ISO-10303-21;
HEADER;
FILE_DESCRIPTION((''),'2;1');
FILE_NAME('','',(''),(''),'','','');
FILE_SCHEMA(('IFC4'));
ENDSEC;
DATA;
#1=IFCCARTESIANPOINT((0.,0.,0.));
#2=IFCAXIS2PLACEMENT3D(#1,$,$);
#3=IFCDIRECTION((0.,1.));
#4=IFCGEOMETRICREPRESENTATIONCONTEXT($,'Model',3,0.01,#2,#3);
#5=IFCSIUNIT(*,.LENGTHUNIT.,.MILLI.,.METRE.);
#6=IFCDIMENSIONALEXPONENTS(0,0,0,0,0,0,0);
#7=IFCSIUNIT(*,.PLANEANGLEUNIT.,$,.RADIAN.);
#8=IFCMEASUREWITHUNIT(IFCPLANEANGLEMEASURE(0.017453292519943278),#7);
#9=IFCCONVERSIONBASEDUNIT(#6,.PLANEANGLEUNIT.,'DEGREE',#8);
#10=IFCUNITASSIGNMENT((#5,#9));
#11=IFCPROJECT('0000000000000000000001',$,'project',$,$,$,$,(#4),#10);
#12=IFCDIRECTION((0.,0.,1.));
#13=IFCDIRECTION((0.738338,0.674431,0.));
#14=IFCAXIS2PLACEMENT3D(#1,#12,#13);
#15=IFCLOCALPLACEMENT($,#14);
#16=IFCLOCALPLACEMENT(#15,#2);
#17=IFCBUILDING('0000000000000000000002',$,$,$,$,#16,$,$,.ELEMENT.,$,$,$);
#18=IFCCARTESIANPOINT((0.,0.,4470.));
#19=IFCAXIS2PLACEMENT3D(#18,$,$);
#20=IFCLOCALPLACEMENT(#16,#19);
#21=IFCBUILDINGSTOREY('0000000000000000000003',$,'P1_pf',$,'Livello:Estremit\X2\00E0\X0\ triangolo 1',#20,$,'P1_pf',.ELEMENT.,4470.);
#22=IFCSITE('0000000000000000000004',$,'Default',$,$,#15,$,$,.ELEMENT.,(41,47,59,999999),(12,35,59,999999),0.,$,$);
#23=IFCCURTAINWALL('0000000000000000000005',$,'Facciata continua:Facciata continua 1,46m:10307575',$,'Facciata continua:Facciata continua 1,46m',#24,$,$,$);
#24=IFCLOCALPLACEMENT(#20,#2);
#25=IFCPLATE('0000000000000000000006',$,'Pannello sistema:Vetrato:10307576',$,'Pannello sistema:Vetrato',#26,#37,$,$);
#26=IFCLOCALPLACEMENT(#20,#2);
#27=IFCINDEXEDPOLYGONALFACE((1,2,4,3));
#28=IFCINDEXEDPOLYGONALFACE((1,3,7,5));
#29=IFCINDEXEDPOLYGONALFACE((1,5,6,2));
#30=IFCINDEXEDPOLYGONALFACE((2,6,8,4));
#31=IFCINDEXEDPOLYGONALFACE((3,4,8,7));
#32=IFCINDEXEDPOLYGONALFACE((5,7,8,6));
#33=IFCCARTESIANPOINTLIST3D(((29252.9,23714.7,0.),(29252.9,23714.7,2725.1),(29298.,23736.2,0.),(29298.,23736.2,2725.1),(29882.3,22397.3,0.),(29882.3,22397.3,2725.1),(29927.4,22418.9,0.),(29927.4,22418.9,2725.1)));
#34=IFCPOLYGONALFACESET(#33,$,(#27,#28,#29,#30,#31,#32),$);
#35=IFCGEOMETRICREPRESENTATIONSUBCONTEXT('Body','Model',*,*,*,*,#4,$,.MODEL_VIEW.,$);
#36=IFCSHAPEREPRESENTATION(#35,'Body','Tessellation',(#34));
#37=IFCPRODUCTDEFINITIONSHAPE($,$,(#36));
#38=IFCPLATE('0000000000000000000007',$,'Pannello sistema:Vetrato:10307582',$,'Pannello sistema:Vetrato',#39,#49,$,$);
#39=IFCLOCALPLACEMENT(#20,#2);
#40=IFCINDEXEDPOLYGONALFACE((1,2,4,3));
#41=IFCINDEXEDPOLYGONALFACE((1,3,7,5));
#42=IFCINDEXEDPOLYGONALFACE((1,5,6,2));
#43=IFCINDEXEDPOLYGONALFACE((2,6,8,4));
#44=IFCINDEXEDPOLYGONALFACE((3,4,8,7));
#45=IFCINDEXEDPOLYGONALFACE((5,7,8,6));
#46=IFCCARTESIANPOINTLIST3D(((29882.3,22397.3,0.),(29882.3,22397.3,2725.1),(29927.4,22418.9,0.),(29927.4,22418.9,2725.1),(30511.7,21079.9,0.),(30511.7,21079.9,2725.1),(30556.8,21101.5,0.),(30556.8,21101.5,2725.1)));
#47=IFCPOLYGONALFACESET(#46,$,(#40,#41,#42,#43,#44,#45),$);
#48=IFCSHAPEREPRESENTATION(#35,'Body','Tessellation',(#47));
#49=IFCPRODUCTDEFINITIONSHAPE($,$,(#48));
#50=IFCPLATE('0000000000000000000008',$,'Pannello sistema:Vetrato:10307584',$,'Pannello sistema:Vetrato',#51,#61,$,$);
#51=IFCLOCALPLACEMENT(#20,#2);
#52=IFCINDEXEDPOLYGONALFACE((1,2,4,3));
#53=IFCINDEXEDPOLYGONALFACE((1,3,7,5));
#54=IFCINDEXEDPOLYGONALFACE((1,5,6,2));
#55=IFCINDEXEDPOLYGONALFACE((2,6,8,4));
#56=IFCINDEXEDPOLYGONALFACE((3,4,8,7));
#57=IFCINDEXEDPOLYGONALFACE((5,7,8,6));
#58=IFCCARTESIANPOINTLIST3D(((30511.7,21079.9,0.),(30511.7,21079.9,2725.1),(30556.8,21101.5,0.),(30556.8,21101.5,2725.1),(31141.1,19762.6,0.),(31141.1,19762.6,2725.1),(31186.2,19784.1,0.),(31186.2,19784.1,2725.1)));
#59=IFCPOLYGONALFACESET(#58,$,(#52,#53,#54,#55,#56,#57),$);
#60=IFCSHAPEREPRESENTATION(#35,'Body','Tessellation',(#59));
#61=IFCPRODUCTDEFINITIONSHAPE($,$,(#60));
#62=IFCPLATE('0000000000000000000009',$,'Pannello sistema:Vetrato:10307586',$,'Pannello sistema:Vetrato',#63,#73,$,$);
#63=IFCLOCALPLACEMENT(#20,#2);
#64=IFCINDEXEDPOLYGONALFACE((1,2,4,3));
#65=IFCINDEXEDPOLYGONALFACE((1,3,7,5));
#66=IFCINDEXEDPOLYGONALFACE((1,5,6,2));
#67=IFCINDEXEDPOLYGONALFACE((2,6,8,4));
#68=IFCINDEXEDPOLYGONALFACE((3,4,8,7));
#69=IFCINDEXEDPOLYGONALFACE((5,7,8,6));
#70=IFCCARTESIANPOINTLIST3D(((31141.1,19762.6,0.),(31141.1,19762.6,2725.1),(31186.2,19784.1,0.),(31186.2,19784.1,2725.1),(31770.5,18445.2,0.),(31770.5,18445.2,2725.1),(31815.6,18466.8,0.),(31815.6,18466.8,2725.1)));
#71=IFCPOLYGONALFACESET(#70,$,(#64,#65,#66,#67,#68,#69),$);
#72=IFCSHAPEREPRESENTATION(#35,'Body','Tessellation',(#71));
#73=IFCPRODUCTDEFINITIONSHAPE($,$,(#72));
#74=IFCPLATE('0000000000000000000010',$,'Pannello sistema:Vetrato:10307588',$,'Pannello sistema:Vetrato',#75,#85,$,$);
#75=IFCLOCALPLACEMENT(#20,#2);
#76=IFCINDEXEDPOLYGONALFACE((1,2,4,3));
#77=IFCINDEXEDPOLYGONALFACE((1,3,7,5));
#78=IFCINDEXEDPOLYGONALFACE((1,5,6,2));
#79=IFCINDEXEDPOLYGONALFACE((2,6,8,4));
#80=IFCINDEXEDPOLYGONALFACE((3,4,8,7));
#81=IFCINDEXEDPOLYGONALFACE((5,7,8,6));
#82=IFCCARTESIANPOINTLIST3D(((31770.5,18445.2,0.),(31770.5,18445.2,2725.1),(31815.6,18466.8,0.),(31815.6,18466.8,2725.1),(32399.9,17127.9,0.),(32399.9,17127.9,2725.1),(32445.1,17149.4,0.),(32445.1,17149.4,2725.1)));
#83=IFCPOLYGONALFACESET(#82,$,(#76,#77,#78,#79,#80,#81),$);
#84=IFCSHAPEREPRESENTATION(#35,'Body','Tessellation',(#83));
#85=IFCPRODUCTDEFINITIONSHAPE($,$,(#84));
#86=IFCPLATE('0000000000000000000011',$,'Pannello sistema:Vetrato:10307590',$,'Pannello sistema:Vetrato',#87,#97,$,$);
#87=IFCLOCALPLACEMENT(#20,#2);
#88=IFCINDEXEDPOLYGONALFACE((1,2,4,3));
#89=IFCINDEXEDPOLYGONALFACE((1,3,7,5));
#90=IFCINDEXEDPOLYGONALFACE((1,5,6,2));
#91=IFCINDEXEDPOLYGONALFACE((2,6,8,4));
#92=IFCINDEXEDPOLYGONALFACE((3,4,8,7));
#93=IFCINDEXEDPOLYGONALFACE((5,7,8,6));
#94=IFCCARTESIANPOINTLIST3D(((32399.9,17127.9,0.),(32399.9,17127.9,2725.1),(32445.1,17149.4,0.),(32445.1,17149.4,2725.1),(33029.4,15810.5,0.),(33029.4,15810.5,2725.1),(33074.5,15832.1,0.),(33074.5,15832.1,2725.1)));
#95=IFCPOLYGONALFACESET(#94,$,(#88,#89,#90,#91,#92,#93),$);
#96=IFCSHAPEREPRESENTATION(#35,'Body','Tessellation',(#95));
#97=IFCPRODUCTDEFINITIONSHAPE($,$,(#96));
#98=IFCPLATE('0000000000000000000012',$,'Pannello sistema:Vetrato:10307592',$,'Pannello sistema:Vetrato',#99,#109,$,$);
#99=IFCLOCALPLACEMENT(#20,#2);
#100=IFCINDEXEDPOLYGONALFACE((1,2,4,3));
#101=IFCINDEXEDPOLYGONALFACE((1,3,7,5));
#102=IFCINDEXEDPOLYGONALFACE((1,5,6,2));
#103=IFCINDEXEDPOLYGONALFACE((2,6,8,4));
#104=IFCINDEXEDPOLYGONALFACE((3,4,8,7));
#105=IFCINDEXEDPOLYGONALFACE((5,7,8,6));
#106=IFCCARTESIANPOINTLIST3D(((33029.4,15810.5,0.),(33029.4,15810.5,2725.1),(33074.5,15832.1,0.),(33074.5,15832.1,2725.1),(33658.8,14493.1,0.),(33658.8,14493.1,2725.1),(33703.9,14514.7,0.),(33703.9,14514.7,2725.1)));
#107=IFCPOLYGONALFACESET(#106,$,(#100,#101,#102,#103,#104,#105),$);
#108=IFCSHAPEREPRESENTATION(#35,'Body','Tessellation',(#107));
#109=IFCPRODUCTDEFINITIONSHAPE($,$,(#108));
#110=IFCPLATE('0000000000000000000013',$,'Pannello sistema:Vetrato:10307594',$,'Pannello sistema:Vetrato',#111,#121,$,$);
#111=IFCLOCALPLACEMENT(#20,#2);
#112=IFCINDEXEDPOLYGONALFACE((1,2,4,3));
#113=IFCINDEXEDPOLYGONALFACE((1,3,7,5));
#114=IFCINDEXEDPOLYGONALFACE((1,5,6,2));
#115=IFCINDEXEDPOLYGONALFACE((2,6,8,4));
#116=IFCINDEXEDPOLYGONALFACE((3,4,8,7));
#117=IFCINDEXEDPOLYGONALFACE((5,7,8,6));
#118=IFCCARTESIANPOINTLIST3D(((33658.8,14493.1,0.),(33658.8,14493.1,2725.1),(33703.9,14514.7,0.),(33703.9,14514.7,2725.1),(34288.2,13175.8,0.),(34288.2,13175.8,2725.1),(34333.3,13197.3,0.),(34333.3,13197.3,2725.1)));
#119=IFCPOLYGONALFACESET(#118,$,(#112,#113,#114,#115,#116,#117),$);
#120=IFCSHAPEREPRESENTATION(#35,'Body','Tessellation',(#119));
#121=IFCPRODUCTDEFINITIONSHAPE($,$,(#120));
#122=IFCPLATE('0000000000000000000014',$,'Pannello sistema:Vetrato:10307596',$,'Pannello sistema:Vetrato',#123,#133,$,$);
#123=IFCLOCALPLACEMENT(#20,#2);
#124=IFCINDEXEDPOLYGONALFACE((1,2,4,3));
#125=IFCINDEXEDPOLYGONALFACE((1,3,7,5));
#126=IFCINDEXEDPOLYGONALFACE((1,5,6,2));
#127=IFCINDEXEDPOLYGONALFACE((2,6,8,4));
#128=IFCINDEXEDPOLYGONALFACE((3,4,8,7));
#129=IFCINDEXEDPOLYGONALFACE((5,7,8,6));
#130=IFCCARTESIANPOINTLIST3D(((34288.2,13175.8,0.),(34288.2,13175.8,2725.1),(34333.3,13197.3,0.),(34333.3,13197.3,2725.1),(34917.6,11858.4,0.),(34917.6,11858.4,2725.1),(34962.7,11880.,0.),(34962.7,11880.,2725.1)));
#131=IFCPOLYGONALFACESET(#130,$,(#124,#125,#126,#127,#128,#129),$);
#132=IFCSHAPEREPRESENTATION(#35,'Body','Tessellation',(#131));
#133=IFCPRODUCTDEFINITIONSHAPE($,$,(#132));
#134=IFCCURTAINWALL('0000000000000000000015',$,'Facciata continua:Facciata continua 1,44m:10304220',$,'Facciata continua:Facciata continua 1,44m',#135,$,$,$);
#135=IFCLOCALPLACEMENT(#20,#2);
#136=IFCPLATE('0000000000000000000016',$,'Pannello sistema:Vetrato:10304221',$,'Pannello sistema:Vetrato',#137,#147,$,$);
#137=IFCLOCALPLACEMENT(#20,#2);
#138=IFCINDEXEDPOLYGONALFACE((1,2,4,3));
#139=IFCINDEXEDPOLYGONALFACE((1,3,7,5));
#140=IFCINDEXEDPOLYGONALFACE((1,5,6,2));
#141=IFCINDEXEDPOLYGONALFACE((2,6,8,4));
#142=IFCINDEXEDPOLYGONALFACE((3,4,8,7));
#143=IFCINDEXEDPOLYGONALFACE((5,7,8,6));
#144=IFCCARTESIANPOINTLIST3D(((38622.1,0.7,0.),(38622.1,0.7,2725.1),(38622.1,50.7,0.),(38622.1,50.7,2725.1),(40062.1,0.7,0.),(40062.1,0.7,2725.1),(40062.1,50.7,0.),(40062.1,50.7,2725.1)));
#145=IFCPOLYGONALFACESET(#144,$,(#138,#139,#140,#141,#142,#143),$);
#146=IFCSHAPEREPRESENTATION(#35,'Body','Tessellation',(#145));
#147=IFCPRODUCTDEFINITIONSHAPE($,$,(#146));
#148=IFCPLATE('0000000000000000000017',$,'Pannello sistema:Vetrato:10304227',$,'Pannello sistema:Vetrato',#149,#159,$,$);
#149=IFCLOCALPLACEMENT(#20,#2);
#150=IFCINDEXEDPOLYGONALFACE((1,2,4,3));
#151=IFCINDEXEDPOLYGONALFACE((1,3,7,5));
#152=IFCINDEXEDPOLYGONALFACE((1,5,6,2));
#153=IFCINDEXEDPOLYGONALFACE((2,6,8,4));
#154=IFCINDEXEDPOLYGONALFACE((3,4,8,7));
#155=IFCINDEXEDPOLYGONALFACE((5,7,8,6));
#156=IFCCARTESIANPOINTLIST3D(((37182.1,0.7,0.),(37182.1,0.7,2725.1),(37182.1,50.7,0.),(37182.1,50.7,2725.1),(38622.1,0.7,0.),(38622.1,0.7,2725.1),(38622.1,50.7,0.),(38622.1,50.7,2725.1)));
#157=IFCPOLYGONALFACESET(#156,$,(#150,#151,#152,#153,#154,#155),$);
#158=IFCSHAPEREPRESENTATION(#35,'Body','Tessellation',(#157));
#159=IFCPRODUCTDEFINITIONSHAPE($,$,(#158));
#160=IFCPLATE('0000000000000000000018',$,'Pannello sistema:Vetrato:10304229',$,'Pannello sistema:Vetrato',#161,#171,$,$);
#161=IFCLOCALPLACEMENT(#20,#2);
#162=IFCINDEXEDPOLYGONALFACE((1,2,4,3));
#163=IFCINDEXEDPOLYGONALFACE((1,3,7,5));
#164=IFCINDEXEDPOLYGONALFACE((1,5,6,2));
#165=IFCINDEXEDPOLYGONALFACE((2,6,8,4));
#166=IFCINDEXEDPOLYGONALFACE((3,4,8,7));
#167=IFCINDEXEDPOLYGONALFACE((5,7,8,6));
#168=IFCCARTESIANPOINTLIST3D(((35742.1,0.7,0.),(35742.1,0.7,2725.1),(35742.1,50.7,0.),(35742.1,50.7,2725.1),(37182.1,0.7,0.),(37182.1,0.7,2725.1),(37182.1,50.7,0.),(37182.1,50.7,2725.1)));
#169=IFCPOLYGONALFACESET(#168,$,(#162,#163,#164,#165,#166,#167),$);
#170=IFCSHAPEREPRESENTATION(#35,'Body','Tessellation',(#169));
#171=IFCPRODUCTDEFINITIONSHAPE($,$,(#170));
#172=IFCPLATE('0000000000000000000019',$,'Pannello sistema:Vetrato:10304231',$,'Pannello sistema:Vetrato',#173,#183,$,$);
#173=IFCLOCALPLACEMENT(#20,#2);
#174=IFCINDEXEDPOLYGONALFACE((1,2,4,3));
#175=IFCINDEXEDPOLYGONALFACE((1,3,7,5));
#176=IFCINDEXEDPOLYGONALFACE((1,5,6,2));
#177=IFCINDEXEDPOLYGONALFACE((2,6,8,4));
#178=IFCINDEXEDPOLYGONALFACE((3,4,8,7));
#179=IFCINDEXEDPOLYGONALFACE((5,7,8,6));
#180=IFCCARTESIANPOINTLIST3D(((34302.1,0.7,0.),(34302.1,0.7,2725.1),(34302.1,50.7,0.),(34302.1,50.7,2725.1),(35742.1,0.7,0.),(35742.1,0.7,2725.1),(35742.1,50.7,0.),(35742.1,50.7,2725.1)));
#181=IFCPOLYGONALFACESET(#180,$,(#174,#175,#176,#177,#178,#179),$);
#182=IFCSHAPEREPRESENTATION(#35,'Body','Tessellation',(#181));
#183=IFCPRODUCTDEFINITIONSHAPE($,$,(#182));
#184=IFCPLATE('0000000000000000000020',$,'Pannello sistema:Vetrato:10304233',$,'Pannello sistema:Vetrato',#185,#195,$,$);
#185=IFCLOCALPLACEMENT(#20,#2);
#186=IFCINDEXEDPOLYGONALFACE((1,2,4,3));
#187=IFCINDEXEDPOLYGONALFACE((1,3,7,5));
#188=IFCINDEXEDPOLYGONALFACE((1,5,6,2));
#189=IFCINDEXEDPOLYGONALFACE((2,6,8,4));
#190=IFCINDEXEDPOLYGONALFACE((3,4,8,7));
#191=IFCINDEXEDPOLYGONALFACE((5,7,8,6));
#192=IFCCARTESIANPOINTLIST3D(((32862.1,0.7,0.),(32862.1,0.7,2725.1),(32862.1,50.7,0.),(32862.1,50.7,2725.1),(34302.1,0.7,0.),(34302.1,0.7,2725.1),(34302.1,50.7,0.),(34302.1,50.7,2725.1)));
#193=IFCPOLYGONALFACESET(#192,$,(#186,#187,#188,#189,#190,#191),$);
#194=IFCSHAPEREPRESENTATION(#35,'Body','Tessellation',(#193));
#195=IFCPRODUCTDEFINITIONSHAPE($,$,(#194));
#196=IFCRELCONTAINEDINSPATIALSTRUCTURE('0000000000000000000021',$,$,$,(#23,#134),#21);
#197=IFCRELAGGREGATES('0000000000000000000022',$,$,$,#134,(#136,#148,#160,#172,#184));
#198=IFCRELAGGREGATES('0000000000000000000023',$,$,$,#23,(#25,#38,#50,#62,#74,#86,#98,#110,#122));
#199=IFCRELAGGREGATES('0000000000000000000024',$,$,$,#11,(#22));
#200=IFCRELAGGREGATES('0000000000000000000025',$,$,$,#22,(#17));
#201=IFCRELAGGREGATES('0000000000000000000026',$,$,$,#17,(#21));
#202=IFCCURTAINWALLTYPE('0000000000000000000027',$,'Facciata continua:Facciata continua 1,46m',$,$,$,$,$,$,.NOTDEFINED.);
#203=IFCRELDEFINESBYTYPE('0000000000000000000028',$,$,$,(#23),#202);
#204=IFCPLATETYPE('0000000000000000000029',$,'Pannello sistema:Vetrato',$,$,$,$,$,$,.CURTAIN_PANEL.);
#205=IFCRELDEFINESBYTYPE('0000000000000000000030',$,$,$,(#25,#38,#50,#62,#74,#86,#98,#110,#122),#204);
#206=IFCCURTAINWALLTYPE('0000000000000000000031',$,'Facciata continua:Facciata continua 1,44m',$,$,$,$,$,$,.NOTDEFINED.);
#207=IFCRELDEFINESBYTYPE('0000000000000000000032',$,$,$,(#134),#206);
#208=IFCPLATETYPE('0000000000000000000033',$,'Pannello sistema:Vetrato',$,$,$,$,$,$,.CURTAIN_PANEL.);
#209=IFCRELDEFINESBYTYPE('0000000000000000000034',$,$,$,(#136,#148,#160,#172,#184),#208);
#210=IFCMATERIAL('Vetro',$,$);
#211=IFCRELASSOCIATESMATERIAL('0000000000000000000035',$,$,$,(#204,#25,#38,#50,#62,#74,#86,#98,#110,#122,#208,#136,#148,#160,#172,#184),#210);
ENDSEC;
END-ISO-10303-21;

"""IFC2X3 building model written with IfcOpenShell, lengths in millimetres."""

from ifc_helpers import new_model, entity, si_unit, converted_unit, direction, frame, origin, origin_2d_with_axis, place, context, subcontext, project, spatial, rectangle, extrude, source, transform, mapped, material, type_object, type_shapes, element, aggregate, save


model = new_model("IFC2X3")

# Units and contexts
model_context = context("Model", 3, precision=0.01, world=origin(), true_north=direction((0.0, 1.0)))
body_context = subcontext(model_context, "Body", "Model", "MODEL_VIEW")
ifc_project = project(units=[si_unit("LENGTHUNIT", "METRE", prefix="MILLI"), converted_unit("PLANEANGLEUNIT", "DEGREE", entity("IfcPlaneAngleMeasure", 0.017453292519943278), si_unit("PLANEANGLEUNIT", "RADIAN"), dimensions=[0, 0, 0, 0, 0, 0, 0])], contexts=[model_context])

# Site, building, storey
site_placement = place(None, frame((0.0, 0.0, 0.0), z_axis=(0.0, 0.0, 1.0), x_axis=(0.738338, 0.674431, 0.0)))
site = spatial("IfcSite", under=ifc_project, at=site_placement, Name="Default", CompositionType="ELEMENT", RefLatitude=(41, 47, 59, 999999), RefLongitude=(12, 35, 59, 999999), RefElevation=0.0)
building_placement = place(site_placement, origin())
building = spatial("IfcBuilding", under=site, at=building_placement, CompositionType="ELEMENT")
storey_placement = place(building_placement, frame((0.0, 0.0, 4470.0)))
storey = spatial("IfcBuildingStorey", under=building, at=storey_placement, Name="P1_pf", ObjectType="Livello:Estremità triangolo 1", LongName="P1_pf", CompositionType="ELEMENT", Elevation=4470.0)

# Curtain walls, plates
curtain_wall_type_1 = type_object("IfcCurtainWallType", Name="Facciata continua:Facciata continua 1,46m", PredefinedType="NOTDEFINED")
curtain_wall_1_placement = place(storey_placement, frame((0.0, 0.0, -4470.0)))
curtain_wall_1 = element("IfcCurtainWall", 1, at=curtain_wall_1_placement, inside=storey, type_object=curtain_wall_type_1, Name="Facciata continua:Facciata continua 1,46m:10307575", ObjectType="Facciata continua:Facciata continua 1,46m")
ifc_material_1 = material(Name="Vetro")
plate_type_1 = type_object("IfcPlateType", Name="Pannello sistema:Vetrato", PredefinedType="CURTAIN_PANEL", material=ifc_material_1)
shared_shape_1 = source(origin(), body_context, "Body", "SweptSolid", [
    extrude(rectangle(XDim=50.0, YDim=1460.0, at=origin_2d_with_axis()), frame((0.0, -25.0, 0.0), z_axis=(0.0, 0.0, 1.0), x_axis=(0.0, 1.0, 0.0)), (0.0, 0.0, 1.0), 2725.1),
])
type_shapes(plate_type_1, [shared_shape_1])
plate_1_placement = place(curtain_wall_1_placement, frame((29612.7, 23077.5, 4470.0), z_axis=(0.0, 0.0, 1.0), x_axis=(0.431105, -0.902302, 0.0)))
plate_1 = element("IfcPlate", 2, at=plate_1_placement, type_object=plate_type_1, material=ifc_material_1, Name="Pannello sistema:Vetrato:10307576", ObjectType="Pannello sistema:Vetrato", context=body_context, shape_type="MappedRepresentation", body=[
    mapped(shared_shape_1, transform((0.0, 0.0, 0.0), scale=1.0)),
])
plate_2_placement = place(curtain_wall_1_placement, frame((30242.1, 21760.2, 4470.0), z_axis=(0.0, 0.0, 1.0), x_axis=(0.431105, -0.902302, 0.0)))
plate_2 = element("IfcPlate", 3, at=plate_2_placement, type_object=plate_type_1, material=ifc_material_1, Name="Pannello sistema:Vetrato:10307582", ObjectType="Pannello sistema:Vetrato", context=body_context, shape_type="MappedRepresentation", body=[
    mapped(shared_shape_1, transform((0.0, 0.0, 0.0), scale=1.0)),
])
plate_3_placement = place(curtain_wall_1_placement, frame((30871.5, 20442.8, 4470.0), z_axis=(0.0, 0.0, 1.0), x_axis=(0.431105, -0.902302, 0.0)))
plate_3 = element("IfcPlate", 4, at=plate_3_placement, type_object=plate_type_1, material=ifc_material_1, Name="Pannello sistema:Vetrato:10307584", ObjectType="Pannello sistema:Vetrato", context=body_context, shape_type="MappedRepresentation", body=[
    mapped(shared_shape_1, transform((0.0, 0.0, 0.0), scale=1.0)),
])
plate_4_placement = place(curtain_wall_1_placement, frame((31500.9, 19125.5, 4470.0), z_axis=(0.0, 0.0, 1.0), x_axis=(0.431105, -0.902302, 0.0)))
plate_4 = element("IfcPlate", 5, at=plate_4_placement, type_object=plate_type_1, material=ifc_material_1, Name="Pannello sistema:Vetrato:10307586", ObjectType="Pannello sistema:Vetrato", context=body_context, shape_type="MappedRepresentation", body=[
    mapped(shared_shape_1, transform((0.0, 0.0, 0.0), scale=1.0)),
])
plate_5_placement = place(curtain_wall_1_placement, frame((32130.3, 17808.1, 4470.0), z_axis=(0.0, 0.0, 1.0), x_axis=(0.431105, -0.902302, 0.0)))
plate_5 = element("IfcPlate", 6, at=plate_5_placement, type_object=plate_type_1, material=ifc_material_1, Name="Pannello sistema:Vetrato:10307588", ObjectType="Pannello sistema:Vetrato", context=body_context, shape_type="MappedRepresentation", body=[
    mapped(shared_shape_1, transform((0.0, 0.0, 0.0), scale=1.0)),
])
plate_6_placement = place(curtain_wall_1_placement, frame((32759.8, 16490.7, 4470.0), z_axis=(0.0, 0.0, 1.0), x_axis=(0.431105, -0.902302, 0.0)))
plate_6 = element("IfcPlate", 7, at=plate_6_placement, type_object=plate_type_1, material=ifc_material_1, Name="Pannello sistema:Vetrato:10307590", ObjectType="Pannello sistema:Vetrato", context=body_context, shape_type="MappedRepresentation", body=[
    mapped(shared_shape_1, transform((0.0, 0.0, 0.0), scale=1.0)),
])
plate_7_placement = place(curtain_wall_1_placement, frame((33389.2, 15173.4, 4470.0), z_axis=(0.0, 0.0, 1.0), x_axis=(0.431105, -0.902302, 0.0)))
plate_7 = element("IfcPlate", 8, at=plate_7_placement, type_object=plate_type_1, material=ifc_material_1, Name="Pannello sistema:Vetrato:10307592", ObjectType="Pannello sistema:Vetrato", context=body_context, shape_type="MappedRepresentation", body=[
    mapped(shared_shape_1, transform((0.0, 0.0, 0.0), scale=1.0)),
])
plate_8_placement = place(curtain_wall_1_placement, frame((34018.6, 13856.0, 4470.0), z_axis=(0.0, 0.0, 1.0), x_axis=(0.431105, -0.902302, 0.0)))
plate_8 = element("IfcPlate", 9, at=plate_8_placement, type_object=plate_type_1, material=ifc_material_1, Name="Pannello sistema:Vetrato:10307594", ObjectType="Pannello sistema:Vetrato", context=body_context, shape_type="MappedRepresentation", body=[
    mapped(shared_shape_1, transform((0.0, 0.0, 0.0), scale=1.0)),
])
plate_9_placement = place(curtain_wall_1_placement, frame((34648.0, 12538.7, 4470.0), z_axis=(0.0, 0.0, 1.0), x_axis=(0.431105, -0.902302, 0.0)))
plate_9 = element("IfcPlate", 10, at=plate_9_placement, type_object=plate_type_1, material=ifc_material_1, Name="Pannello sistema:Vetrato:10307596", ObjectType="Pannello sistema:Vetrato", context=body_context, shape_type="MappedRepresentation", body=[
    mapped(shared_shape_1, transform((0.0, 0.0, 0.0), scale=1.0)),
])
curtain_wall_type_2 = type_object("IfcCurtainWallType", Name="Facciata continua:Facciata continua 1,44m", PredefinedType="NOTDEFINED")
curtain_wall_2_placement = place(storey_placement, frame((0.0, 0.0, -4470.0)))
curtain_wall_2 = element("IfcCurtainWall", 11, at=curtain_wall_2_placement, inside=storey, type_object=curtain_wall_type_2, Name="Facciata continua:Facciata continua 1,44m:10304220", ObjectType="Facciata continua:Facciata continua 1,44m")
plate_type_2 = type_object("IfcPlateType", Name="Pannello sistema:Vetrato", PredefinedType="CURTAIN_PANEL", material=ifc_material_1)
shared_shape_2 = source(origin(), body_context, "Body", "SweptSolid", [
    extrude(rectangle(XDim=50.0, YDim=1440.0, at=origin_2d_with_axis()), frame((0.0, -25.0, 0.0), z_axis=(0.0, 0.0, 1.0), x_axis=(0.0, 1.0, 0.0)), (0.0, 0.0, 1.0), 2725.1),
])
type_shapes(plate_type_2, [shared_shape_2])
plate_10_placement = place(curtain_wall_2_placement, frame((39342.1, 0.7, 4470.0), z_axis=(0.0, 0.0, 1.0), x_axis=(-1.0, 0.0, 0.0)))
plate_10 = element("IfcPlate", 12, at=plate_10_placement, type_object=plate_type_2, material=ifc_material_1, Name="Pannello sistema:Vetrato:10304221", ObjectType="Pannello sistema:Vetrato", context=body_context, shape_type="MappedRepresentation", body=[
    mapped(shared_shape_2, transform((0.0, 0.0, 0.0), scale=1.0)),
])
plate_11_placement = place(curtain_wall_2_placement, frame((37902.1, 0.7, 4470.0), z_axis=(0.0, 0.0, 1.0), x_axis=(-1.0, 0.0, 0.0)))
plate_11 = element("IfcPlate", 13, at=plate_11_placement, type_object=plate_type_2, material=ifc_material_1, Name="Pannello sistema:Vetrato:10304227", ObjectType="Pannello sistema:Vetrato", context=body_context, shape_type="MappedRepresentation", body=[
    mapped(shared_shape_2, transform((0.0, 0.0, 0.0), scale=1.0)),
])
plate_12_placement = place(curtain_wall_2_placement, frame((36462.1, 0.7, 4470.0), z_axis=(0.0, 0.0, 1.0), x_axis=(-1.0, 0.0, 0.0)))
plate_12 = element("IfcPlate", 14, at=plate_12_placement, type_object=plate_type_2, material=ifc_material_1, Name="Pannello sistema:Vetrato:10304229", ObjectType="Pannello sistema:Vetrato", context=body_context, shape_type="MappedRepresentation", body=[
    mapped(shared_shape_2, transform((0.0, 0.0, 0.0), scale=1.0)),
])
plate_13_placement = place(curtain_wall_2_placement, frame((35022.1, 0.7, 4470.0), z_axis=(0.0, 0.0, 1.0), x_axis=(-1.0, 0.0, 0.0)))
plate_13 = element("IfcPlate", 15, at=plate_13_placement, type_object=plate_type_2, material=ifc_material_1, Name="Pannello sistema:Vetrato:10304231", ObjectType="Pannello sistema:Vetrato", context=body_context, shape_type="MappedRepresentation", body=[
    mapped(shared_shape_2, transform((0.0, 0.0, 0.0), scale=1.0)),
])
plate_14_placement = place(curtain_wall_2_placement, frame((33582.1, 0.7, 4470.0), z_axis=(0.0, 0.0, 1.0), x_axis=(-1.0, 0.0, 0.0)))
plate_14 = element("IfcPlate", 16, at=plate_14_placement, type_object=plate_type_2, material=ifc_material_1, Name="Pannello sistema:Vetrato:10304233", ObjectType="Pannello sistema:Vetrato", context=body_context, shape_type="MappedRepresentation", body=[
    mapped(shared_shape_2, transform((0.0, 0.0, 0.0), scale=1.0)),
])
aggregate(curtain_wall_2, [plate_10, plate_11, plate_12, plate_13, plate_14])

aggregate(curtain_wall_1, [plate_1, plate_2, plate_3, plate_4, plate_5, plate_6, plate_7, plate_8, plate_9])

save(model, "model.ifc")
